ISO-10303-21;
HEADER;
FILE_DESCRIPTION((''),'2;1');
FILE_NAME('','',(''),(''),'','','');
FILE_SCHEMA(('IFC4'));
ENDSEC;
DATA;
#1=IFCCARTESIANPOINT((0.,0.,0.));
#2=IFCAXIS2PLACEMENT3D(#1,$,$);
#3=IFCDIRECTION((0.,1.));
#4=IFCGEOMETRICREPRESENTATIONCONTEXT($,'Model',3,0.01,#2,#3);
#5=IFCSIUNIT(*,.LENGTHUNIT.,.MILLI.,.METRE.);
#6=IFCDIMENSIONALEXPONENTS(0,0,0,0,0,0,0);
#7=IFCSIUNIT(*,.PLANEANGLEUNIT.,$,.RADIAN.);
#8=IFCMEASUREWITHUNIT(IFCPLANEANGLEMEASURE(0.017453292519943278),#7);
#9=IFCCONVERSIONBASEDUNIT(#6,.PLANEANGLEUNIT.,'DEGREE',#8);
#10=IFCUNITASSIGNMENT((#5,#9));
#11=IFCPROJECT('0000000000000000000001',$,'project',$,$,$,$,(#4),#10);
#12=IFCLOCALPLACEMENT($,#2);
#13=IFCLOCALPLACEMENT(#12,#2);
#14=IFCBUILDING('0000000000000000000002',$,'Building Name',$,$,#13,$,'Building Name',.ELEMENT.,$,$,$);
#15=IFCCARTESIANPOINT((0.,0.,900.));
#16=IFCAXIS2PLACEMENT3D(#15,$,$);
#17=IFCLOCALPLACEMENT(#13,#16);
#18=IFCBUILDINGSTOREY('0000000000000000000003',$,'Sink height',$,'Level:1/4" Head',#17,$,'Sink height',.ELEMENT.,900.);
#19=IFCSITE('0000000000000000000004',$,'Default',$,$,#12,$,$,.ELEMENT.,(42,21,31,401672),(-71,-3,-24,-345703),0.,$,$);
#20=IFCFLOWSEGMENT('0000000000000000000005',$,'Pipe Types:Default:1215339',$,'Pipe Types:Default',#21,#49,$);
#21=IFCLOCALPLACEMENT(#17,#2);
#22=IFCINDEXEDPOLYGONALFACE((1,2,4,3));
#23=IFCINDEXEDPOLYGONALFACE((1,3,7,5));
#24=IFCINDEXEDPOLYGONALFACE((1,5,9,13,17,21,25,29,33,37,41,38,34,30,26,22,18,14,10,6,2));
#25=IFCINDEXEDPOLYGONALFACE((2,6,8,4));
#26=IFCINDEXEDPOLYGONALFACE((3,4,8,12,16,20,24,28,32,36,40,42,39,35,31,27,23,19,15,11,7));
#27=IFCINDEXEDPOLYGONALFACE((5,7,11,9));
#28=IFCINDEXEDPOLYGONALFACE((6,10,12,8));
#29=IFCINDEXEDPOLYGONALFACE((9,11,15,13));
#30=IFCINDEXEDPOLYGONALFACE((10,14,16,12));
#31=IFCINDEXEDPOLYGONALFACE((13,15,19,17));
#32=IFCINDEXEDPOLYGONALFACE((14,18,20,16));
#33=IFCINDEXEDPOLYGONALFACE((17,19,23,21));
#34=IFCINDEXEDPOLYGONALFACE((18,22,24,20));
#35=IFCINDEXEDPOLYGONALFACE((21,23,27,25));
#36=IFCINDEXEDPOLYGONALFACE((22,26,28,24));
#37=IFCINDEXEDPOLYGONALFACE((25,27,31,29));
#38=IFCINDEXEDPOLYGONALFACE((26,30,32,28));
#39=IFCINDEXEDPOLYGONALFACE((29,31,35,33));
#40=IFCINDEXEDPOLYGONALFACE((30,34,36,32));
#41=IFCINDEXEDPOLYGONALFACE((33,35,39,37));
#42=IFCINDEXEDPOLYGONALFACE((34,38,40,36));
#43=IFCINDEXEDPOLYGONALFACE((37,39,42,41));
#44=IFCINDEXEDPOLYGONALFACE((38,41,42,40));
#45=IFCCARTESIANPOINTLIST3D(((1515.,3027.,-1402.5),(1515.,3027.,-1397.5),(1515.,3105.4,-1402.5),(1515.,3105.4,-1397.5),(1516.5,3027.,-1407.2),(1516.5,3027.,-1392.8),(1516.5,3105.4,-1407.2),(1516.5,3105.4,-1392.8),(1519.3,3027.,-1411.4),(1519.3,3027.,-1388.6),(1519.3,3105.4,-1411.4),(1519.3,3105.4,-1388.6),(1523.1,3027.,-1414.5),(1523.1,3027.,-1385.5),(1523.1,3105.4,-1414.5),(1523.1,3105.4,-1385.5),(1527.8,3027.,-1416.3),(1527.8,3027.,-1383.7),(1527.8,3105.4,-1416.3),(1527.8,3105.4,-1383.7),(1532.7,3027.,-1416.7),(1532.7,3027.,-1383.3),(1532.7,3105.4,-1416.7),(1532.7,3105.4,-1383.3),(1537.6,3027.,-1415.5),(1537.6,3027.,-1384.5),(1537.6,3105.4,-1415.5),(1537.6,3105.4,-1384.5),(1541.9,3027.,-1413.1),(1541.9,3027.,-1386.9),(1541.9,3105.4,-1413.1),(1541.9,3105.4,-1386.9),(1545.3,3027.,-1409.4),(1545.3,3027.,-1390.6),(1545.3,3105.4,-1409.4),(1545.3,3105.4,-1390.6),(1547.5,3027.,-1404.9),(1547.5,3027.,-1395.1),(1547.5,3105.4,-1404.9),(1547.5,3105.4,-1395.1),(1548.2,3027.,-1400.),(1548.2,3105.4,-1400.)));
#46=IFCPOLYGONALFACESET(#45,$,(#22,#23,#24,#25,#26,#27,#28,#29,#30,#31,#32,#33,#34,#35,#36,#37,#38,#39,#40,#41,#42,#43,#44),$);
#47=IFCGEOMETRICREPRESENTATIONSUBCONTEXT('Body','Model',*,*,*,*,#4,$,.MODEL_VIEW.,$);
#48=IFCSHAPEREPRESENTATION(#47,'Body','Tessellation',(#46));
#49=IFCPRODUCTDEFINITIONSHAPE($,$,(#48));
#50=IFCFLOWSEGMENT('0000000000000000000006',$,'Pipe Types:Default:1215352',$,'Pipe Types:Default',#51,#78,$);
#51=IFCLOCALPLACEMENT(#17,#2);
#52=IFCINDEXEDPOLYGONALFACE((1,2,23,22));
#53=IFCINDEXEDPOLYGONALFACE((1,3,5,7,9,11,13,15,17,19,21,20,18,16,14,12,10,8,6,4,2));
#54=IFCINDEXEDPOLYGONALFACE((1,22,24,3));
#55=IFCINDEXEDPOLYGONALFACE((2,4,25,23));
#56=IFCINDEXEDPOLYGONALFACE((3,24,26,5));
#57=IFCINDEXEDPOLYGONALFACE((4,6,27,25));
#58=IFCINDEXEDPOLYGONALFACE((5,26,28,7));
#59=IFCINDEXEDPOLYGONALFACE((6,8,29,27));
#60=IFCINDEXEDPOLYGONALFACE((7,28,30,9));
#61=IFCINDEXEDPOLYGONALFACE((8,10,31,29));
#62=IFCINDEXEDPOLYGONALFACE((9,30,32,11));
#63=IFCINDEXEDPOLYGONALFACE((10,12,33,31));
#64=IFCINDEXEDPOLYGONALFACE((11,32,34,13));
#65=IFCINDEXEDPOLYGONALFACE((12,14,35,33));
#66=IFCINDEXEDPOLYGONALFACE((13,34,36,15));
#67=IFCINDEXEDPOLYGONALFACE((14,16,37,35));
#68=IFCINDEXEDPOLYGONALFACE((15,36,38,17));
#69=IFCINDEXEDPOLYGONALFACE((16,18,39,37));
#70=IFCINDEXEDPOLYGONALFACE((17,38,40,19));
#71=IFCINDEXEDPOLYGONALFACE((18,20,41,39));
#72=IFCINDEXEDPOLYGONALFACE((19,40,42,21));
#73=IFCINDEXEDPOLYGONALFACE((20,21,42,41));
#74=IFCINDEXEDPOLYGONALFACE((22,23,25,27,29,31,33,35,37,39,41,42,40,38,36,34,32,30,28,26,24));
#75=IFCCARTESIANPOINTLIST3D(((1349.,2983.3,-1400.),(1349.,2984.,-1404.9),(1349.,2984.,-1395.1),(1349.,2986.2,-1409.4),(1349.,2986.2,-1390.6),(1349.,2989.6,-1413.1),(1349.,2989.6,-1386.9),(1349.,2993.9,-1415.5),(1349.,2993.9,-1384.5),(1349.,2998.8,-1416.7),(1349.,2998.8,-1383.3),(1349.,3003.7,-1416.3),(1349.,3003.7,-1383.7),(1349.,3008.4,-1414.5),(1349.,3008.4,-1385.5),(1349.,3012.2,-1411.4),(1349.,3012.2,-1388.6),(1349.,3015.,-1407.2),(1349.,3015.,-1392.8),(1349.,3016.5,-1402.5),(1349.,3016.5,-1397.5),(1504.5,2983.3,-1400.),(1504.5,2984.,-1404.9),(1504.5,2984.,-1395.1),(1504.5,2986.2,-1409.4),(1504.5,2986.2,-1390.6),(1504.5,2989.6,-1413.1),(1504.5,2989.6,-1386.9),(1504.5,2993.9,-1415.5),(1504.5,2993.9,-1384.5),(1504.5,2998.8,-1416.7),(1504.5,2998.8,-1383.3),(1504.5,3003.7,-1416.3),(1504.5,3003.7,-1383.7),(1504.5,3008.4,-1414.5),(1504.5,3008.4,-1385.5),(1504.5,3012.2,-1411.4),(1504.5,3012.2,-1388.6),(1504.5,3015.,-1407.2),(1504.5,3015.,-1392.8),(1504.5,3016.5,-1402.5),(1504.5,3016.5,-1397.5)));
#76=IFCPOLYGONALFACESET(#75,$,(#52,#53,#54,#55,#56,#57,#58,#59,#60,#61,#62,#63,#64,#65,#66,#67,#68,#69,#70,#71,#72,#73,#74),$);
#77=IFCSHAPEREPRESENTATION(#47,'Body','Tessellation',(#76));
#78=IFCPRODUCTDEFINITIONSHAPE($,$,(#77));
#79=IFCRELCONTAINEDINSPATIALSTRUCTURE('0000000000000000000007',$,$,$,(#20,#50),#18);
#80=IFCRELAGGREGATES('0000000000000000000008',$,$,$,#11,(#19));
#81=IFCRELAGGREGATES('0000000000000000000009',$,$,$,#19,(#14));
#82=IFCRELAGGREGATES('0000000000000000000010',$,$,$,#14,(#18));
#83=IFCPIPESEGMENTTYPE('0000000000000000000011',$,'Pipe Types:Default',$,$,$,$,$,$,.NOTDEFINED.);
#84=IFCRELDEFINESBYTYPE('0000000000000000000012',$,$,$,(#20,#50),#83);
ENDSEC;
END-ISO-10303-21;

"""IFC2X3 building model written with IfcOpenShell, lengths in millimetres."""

from ifc_helpers import new_model, entity, si_unit, converted_unit, direction, frame, origin, origin_2d_with_axis, place, context, subcontext, project, spatial, circle, extrude, type_object, element, save


model = new_model("IFC2X3")

# Units and contexts
model_context = context("Model", 3, precision=0.01, world=origin(), true_north=direction((0.0, 1.0)))
body_context = subcontext(model_context, "Body", "Model", "MODEL_VIEW")
ifc_project = project(units=[si_unit("LENGTHUNIT", "METRE", prefix="MILLI"), converted_unit("PLANEANGLEUNIT", "DEGREE", entity("IfcPlaneAngleMeasure", 0.017453292519943278), si_unit("PLANEANGLEUNIT", "RADIAN"), dimensions=[0, 0, 0, 0, 0, 0, 0])], contexts=[model_context])

# Site, building, storey
site_placement = place(None, origin())
site = spatial("IfcSite", under=ifc_project, at=site_placement, Name="Default", CompositionType="ELEMENT", RefLatitude=(42, 21, 31, 401672), RefLongitude=(-71, -3, -24, -345703), RefElevation=0.0)
building_placement = place(site_placement, origin())
building = spatial("IfcBuilding", under=site, at=building_placement, Name="Building Name", LongName="Building Name", CompositionType="ELEMENT")
storey_placement = place(building_placement, frame((0.0, 0.0, 900.0)))
storey = spatial("IfcBuildingStorey", under=building, at=storey_placement, Name="Sink height", ObjectType="Level:1/4\" Head", LongName="Sink height", CompositionType="ELEMENT", Elevation=900.0)

# Flow segments
pipe_segment_type = type_object("IfcPipeSegmentType", Name="Pipe Types:Default", PredefinedType="NOTDEFINED")
flow_segment_1_placement = place(storey_placement, origin())
element("IfcFlowSegment", 1, at=flow_segment_1_placement, inside=storey, type_object=pipe_segment_type, Name="Pipe Types:Default:1215339", ObjectType="Pipe Types:Default", context=body_context, shape_type="SweptSolid", body=[
    extrude(circle(Radius=16.7, at=origin_2d_with_axis()), frame((1531.5, 3027.0, -1400.0), z_axis=(0.0, 1.0, 0.0), x_axis=(1.0, 0.0, 0.0)), (0.0, 0.0, 1.0), 78.4),
])
flow_segment_2_placement = place(storey_placement, origin())
element("IfcFlowSegment", 2, at=flow_segment_2_placement, inside=storey, type_object=pipe_segment_type, Name="Pipe Types:Default:1215352", ObjectType="Pipe Types:Default", context=body_context, shape_type="SweptSolid", body=[
    extrude(circle(Radius=16.7, at=origin_2d_with_axis()), frame((1349.0, 3000.0, -1400.0), z_axis=(1.0, 0.0, 0.0), x_axis=(0.0, -1.0, 0.0)), (0.0, 0.0, 1.0), 155.5),
])

save(model, "model.ifc")
